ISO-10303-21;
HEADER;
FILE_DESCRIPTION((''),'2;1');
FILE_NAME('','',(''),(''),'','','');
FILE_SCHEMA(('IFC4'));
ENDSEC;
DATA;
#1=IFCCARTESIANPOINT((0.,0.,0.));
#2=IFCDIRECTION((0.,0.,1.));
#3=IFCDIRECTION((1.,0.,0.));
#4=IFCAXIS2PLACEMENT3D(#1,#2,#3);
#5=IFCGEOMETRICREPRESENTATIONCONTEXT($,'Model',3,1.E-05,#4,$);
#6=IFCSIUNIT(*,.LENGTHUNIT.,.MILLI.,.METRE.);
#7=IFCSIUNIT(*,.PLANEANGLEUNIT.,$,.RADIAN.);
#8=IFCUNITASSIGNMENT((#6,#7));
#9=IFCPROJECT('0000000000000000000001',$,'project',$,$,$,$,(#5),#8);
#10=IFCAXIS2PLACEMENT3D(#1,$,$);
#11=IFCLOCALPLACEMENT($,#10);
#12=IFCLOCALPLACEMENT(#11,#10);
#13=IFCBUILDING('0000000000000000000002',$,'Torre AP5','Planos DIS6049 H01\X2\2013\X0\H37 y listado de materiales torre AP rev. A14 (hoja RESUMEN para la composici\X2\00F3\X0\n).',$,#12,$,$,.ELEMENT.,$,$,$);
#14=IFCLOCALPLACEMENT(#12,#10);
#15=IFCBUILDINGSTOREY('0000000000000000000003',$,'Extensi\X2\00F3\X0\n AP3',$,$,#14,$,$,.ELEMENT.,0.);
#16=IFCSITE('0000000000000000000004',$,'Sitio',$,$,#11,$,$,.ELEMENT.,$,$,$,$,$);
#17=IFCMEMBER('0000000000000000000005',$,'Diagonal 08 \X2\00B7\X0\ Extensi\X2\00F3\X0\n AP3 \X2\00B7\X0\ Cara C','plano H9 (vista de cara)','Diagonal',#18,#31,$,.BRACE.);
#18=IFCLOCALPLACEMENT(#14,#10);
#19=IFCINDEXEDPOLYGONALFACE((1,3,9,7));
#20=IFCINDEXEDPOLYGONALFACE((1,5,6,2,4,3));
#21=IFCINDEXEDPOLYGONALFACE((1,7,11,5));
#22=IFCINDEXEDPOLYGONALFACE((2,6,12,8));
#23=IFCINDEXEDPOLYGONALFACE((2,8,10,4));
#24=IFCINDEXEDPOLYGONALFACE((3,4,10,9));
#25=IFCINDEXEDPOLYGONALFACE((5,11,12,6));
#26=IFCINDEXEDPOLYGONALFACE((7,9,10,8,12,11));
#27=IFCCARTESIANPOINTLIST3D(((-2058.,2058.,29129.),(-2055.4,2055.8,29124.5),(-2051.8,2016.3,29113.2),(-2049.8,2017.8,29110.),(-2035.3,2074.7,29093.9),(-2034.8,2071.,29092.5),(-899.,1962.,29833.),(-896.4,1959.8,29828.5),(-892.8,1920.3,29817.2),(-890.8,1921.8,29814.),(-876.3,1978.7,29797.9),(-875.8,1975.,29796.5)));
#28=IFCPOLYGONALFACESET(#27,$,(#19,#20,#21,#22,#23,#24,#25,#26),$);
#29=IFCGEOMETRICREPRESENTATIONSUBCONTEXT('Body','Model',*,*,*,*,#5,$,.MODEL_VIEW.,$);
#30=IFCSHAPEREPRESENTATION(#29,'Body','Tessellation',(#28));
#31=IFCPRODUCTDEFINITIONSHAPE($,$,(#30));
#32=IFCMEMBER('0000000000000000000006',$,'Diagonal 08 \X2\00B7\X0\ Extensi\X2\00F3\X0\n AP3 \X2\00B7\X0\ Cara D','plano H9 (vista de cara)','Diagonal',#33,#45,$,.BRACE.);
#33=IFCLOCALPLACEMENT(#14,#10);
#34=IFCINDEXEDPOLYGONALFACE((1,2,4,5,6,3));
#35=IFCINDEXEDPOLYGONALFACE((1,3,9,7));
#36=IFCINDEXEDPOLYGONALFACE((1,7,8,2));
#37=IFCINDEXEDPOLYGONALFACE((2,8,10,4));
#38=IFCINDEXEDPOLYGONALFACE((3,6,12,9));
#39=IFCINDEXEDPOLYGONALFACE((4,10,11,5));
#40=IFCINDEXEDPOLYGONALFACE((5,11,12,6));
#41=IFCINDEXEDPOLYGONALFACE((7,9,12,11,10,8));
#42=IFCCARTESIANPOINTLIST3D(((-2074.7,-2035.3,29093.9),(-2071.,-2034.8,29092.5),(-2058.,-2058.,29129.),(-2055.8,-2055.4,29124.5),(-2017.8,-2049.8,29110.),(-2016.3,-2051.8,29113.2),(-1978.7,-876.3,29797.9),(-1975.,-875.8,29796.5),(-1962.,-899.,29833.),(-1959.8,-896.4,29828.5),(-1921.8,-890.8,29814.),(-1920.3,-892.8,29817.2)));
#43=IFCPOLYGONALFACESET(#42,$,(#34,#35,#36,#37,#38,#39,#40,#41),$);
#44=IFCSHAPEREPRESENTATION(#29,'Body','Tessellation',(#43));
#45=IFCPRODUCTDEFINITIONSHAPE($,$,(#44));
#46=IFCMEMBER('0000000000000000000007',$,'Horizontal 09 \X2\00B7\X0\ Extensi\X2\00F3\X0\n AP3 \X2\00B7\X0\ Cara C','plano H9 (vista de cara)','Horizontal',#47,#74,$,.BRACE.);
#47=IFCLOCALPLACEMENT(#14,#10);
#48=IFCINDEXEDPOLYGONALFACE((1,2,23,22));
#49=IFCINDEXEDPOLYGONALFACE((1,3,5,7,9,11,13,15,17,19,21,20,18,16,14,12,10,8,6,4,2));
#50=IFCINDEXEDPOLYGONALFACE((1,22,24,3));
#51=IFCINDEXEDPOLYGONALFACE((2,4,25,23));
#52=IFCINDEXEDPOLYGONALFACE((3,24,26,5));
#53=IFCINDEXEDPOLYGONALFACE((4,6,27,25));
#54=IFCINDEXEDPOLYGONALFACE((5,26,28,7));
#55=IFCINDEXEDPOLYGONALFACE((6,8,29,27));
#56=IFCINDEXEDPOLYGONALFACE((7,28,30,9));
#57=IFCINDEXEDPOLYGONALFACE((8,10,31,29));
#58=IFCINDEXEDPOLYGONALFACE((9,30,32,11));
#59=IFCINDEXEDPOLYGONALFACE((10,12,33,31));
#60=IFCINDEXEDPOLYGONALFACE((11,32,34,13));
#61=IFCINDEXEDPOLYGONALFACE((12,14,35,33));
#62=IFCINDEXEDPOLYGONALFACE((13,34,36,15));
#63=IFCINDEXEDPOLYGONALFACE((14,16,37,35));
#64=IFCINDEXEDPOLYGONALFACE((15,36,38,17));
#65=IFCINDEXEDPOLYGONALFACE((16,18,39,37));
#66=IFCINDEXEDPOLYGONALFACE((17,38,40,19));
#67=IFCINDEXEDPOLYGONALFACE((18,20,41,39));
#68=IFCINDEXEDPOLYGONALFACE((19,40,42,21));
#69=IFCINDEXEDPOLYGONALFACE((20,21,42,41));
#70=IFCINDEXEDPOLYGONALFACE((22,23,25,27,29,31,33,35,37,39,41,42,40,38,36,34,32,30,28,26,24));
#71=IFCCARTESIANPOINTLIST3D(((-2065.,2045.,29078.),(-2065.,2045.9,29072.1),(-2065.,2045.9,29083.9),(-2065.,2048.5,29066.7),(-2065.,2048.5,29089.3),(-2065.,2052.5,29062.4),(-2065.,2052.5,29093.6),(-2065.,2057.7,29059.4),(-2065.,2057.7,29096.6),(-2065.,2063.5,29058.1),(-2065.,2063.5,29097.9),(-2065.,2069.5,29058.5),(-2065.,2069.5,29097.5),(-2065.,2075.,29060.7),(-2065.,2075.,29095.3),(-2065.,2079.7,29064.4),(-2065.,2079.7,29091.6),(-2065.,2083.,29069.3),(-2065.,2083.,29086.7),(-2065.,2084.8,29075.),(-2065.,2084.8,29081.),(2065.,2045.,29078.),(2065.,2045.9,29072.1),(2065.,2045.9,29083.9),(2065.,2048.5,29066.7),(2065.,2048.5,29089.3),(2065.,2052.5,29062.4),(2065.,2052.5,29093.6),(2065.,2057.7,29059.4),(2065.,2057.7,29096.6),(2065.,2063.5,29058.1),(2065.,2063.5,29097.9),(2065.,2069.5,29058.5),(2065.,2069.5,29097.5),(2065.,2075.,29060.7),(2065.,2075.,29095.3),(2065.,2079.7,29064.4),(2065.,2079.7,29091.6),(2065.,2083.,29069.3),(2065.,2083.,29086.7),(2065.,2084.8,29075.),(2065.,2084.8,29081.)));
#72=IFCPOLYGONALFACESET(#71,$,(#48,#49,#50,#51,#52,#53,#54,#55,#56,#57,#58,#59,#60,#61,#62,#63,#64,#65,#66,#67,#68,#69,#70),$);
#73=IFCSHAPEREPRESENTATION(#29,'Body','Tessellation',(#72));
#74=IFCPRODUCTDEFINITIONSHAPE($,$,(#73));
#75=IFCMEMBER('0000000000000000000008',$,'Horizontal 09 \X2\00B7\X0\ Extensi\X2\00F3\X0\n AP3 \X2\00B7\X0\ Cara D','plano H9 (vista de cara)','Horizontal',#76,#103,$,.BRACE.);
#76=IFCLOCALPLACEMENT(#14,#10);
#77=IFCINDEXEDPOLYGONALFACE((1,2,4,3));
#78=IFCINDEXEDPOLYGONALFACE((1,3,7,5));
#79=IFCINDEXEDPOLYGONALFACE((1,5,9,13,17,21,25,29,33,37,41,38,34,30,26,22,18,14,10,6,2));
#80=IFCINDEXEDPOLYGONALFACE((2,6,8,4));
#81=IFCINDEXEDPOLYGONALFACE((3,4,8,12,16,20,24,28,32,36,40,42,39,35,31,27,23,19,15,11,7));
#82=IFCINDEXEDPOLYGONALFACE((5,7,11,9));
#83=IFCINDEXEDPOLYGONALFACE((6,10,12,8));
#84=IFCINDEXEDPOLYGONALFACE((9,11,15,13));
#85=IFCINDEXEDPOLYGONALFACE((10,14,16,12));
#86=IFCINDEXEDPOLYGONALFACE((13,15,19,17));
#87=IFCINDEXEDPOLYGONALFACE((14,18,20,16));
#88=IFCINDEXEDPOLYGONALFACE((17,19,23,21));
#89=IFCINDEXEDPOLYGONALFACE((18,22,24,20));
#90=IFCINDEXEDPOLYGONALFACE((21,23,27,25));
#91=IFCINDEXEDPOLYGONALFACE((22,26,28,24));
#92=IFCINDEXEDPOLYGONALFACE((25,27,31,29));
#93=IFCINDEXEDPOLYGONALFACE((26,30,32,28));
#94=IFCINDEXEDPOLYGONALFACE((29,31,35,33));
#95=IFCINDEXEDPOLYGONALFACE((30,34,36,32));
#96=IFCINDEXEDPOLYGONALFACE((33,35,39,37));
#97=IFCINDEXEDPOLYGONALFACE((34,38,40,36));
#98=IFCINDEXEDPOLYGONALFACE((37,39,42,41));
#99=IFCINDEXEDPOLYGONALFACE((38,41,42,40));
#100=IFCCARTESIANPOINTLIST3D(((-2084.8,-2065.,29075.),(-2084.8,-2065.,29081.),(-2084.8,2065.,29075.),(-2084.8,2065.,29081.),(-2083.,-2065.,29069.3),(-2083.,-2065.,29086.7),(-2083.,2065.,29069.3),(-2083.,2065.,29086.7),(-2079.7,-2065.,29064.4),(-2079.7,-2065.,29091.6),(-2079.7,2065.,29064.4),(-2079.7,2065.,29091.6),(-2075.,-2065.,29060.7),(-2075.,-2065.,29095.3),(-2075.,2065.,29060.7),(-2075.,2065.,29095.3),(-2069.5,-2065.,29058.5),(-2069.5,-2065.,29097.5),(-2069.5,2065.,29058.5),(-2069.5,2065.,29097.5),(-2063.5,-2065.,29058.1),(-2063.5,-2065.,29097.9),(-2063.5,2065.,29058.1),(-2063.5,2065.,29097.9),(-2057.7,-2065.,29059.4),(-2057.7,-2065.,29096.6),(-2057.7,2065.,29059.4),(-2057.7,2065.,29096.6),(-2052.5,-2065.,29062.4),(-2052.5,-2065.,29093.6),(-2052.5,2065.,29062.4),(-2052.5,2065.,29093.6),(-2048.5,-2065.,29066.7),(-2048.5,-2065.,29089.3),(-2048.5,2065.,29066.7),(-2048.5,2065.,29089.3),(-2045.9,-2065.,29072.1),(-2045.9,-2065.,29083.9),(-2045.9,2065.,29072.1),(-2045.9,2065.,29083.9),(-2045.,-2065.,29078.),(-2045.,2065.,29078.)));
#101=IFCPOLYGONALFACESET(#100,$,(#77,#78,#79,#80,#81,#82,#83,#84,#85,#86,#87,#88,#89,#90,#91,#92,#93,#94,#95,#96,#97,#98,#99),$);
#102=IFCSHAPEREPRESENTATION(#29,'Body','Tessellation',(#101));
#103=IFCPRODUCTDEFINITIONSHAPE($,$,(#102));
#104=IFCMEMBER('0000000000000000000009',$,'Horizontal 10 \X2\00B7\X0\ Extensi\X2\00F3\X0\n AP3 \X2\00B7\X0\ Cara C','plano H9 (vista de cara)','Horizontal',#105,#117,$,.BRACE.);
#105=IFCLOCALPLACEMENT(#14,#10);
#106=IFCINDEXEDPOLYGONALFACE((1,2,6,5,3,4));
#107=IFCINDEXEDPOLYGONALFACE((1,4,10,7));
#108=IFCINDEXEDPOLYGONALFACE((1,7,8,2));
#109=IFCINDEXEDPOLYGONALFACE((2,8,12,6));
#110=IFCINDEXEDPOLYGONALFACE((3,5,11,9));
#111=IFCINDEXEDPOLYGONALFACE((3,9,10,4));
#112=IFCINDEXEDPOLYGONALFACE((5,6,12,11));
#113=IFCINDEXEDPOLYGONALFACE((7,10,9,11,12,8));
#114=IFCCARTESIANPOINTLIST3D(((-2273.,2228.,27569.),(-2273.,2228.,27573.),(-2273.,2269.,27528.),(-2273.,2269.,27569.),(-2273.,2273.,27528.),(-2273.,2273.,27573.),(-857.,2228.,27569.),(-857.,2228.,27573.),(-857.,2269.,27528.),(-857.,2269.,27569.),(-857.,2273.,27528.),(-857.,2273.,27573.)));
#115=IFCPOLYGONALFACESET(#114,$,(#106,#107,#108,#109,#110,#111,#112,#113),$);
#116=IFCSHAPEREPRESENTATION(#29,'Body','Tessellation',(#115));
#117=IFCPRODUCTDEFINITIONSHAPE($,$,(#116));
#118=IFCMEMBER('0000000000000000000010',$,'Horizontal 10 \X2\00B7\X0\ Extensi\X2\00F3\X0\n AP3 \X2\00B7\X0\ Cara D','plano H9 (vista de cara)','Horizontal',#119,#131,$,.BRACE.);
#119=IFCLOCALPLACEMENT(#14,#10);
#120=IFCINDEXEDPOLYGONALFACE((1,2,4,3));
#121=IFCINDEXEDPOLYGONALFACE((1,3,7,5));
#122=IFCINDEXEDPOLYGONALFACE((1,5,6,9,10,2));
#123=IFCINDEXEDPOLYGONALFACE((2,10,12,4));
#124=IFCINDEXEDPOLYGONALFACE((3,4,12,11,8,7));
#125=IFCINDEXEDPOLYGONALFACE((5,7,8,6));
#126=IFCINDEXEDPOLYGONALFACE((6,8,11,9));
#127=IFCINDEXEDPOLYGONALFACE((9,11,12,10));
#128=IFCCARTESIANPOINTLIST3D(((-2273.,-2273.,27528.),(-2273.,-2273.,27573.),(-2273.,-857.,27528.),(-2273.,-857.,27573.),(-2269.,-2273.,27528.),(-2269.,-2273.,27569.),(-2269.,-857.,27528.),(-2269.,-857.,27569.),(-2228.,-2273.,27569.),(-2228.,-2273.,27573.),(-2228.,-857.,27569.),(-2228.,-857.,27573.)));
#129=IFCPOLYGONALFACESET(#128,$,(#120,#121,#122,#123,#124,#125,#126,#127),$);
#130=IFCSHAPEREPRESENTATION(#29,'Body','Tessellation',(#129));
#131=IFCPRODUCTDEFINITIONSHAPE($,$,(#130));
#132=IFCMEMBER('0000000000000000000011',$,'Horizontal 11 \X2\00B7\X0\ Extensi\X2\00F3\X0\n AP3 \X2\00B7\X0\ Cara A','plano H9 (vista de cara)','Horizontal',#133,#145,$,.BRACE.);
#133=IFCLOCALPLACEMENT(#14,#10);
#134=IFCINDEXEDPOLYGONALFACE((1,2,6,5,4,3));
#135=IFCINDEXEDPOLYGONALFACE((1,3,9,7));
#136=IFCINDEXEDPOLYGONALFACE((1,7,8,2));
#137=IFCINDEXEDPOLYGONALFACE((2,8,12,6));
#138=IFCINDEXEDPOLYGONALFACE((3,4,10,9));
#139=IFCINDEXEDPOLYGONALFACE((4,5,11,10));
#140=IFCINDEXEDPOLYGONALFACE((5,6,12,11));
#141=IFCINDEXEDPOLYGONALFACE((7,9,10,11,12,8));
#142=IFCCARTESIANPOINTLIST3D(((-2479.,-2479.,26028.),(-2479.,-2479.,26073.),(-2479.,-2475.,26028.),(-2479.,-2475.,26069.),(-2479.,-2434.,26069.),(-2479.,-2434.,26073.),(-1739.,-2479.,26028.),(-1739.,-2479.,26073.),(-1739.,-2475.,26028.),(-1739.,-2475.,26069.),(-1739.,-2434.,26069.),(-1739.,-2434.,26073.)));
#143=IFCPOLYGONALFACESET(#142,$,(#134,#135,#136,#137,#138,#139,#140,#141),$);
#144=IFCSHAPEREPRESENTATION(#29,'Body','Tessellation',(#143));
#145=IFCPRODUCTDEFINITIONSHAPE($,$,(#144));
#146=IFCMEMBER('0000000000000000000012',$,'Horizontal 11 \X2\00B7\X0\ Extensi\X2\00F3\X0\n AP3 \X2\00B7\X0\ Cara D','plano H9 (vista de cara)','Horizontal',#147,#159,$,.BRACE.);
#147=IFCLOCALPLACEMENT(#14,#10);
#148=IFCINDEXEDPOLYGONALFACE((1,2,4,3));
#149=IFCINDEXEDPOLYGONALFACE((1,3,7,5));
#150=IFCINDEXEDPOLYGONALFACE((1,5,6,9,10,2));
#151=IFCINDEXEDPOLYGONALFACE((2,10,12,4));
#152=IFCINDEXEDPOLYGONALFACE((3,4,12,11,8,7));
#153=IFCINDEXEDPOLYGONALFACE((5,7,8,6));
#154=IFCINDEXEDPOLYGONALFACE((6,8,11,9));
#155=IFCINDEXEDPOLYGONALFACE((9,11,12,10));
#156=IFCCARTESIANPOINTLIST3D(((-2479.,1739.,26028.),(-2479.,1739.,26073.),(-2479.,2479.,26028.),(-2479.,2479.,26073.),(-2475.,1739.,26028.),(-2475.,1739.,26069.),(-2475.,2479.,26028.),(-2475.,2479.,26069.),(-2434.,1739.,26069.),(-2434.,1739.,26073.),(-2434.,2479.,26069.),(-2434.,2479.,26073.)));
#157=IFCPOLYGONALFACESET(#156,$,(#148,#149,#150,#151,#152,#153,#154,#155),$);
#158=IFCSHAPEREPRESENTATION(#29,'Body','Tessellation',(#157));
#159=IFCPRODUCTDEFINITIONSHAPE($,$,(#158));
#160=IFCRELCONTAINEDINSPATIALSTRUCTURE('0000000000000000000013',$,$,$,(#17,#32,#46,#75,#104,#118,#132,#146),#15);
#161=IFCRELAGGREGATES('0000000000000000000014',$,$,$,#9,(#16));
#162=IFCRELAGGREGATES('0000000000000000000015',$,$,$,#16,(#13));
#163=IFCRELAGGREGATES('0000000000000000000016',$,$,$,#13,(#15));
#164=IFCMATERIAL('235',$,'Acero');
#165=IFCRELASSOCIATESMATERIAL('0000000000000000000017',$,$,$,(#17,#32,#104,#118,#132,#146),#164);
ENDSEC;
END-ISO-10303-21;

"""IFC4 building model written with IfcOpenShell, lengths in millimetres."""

from ifc_helpers import new_model, si_unit, frame, frame_2d, origin, origin_with_axes, place, context, subcontext, project, spatial, circle, l_section, extrude, material, element, save


model = new_model("IFC4")

# Units and contexts
model_context = context("Model", 3, precision=1e-05, world=origin_with_axes())
body_context = subcontext(model_context, "Body", "Model", "MODEL_VIEW")
ifc_project = project(units=[si_unit("LENGTHUNIT", "METRE", prefix="MILLI"), si_unit("PLANEANGLEUNIT", "RADIAN")], contexts=[model_context])

# Site, building, storey
site_placement = place(None, origin())
site = spatial("IfcSite", under=ifc_project, at=site_placement, Name="Sitio", CompositionType="ELEMENT")
building_placement = place(site_placement, origin())
building = spatial("IfcBuilding", under=site, at=building_placement, Name="Torre AP5", Description="Planos DIS6049 H01–H37 y listado de materiales torre AP rev. A14 (hoja RESUMEN para la composición).", CompositionType="ELEMENT")
storey_placement = place(building_placement, origin())
storey = spatial("IfcBuildingStorey", under=building, at=storey_placement, Name="Extensión AP3", CompositionType="ELEMENT", Elevation=0.0)

# Members
ifc_material_1 = material(Name="235", Category="Acero")
for number, where, z_axis, x_axis, name in (
    (1, (-2058.0, 2058.0, 29129.0), (0.852549, -0.070617, 0.517855), (0.137057, -0.925948, -0.351904), "Diagonal 08 · Extensión AP3 · Cara C"),
    (2, (-2058.0, -2058.0, 29129.0), (0.070617, 0.852549, 0.517855), (0.925948, 0.137057, -0.351904), "Diagonal 08 · Extensión AP3 · Cara D"),
):
    element("IfcMember", number, at=place(storey_placement, frame(where, z_axis=z_axis, x_axis=x_axis)), inside=storey, material=ifc_material_1, Name=name, Description="plano H9 (vista de cara)", ObjectType="Diagonal", PredefinedType="BRACE", context=body_context, shape_type="SweptSolid", body=[
        extrude(l_section(Depth=45.0, Width=45.0, Thickness=4.0, at=frame_2d((22.5, 22.5))), None, (0.0, 0.0, 1.0), 1359.5),
    ])
for number, where, z_axis, x_axis, name in (
    (3, (-2065.0, 2065.0, 29078.0), (1.0, 0.0, 0.0), (0.0, -1.0, 0.0), "Horizontal 09 · Extensión AP3 · Cara C"),
    (4, (-2065.0, -2065.0, 29078.0), (0.0, 1.0, 0.0), (1.0, 0.0, 0.0), "Horizontal 09 · Extensión AP3 · Cara D"),
):
    element("IfcMember", number, at=place(storey_placement, frame(where, z_axis=z_axis, x_axis=x_axis)), inside=storey, Name=name, Description="plano H9 (vista de cara)", ObjectType="Horizontal", PredefinedType="BRACE", context=body_context, shape_type="SweptSolid", body=[
        extrude(circle(Radius=20.0), None, (0.0, 0.0, 1.0), 4130.0),
    ])
for number, where, z_axis, x_axis, name in (
    (5, (-2273.0, 2273.0, 27573.0), (1.0, 0.0, 0.0), (0.0, -1.0, 0.0), "Horizontal 10 · Extensión AP3 · Cara C"),
    (6, (-2273.0, -2273.0, 27573.0), (0.0, 1.0, 0.0), (1.0, 0.0, 0.0), "Horizontal 10 · Extensión AP3 · Cara D"),
):
    element("IfcMember", number, at=place(storey_placement, frame(where, z_axis=z_axis, x_axis=x_axis)), inside=storey, material=ifc_material_1, Name=name, Description="plano H9 (vista de cara)", ObjectType="Horizontal", PredefinedType="BRACE", context=body_context, shape_type="SweptSolid", body=[
        extrude(l_section(Depth=45.0, Width=45.0, Thickness=4.0, at=frame_2d((22.5, 22.5))), None, (0.0, 0.0, 1.0), 1416.0),
    ])
for number, where, z_axis, x_axis, name in (
    (7, (-1739.0, -2479.0, 26073.0), (-1.0, 0.0, 0.0), (0.0, 1.0, 0.0), "Horizontal 11 · Extensión AP3 · Cara A"),
    (8, (-2479.0, 1739.0, 26073.0), (0.0, 1.0, 0.0), (1.0, 0.0, 0.0), "Horizontal 11 · Extensión AP3 · Cara D"),
):
    element("IfcMember", number, at=place(storey_placement, frame(where, z_axis=z_axis, x_axis=x_axis)), inside=storey, material=ifc_material_1, Name=name, Description="plano H9 (vista de cara)", ObjectType="Horizontal", PredefinedType="BRACE", context=body_context, shape_type="SweptSolid", body=[
        extrude(l_section(Depth=45.0, Width=45.0, Thickness=4.0, at=frame_2d((22.5, 22.5))), None, (0.0, 0.0, 1.0), 740.0),
    ])

save(model, "model.ifc")
